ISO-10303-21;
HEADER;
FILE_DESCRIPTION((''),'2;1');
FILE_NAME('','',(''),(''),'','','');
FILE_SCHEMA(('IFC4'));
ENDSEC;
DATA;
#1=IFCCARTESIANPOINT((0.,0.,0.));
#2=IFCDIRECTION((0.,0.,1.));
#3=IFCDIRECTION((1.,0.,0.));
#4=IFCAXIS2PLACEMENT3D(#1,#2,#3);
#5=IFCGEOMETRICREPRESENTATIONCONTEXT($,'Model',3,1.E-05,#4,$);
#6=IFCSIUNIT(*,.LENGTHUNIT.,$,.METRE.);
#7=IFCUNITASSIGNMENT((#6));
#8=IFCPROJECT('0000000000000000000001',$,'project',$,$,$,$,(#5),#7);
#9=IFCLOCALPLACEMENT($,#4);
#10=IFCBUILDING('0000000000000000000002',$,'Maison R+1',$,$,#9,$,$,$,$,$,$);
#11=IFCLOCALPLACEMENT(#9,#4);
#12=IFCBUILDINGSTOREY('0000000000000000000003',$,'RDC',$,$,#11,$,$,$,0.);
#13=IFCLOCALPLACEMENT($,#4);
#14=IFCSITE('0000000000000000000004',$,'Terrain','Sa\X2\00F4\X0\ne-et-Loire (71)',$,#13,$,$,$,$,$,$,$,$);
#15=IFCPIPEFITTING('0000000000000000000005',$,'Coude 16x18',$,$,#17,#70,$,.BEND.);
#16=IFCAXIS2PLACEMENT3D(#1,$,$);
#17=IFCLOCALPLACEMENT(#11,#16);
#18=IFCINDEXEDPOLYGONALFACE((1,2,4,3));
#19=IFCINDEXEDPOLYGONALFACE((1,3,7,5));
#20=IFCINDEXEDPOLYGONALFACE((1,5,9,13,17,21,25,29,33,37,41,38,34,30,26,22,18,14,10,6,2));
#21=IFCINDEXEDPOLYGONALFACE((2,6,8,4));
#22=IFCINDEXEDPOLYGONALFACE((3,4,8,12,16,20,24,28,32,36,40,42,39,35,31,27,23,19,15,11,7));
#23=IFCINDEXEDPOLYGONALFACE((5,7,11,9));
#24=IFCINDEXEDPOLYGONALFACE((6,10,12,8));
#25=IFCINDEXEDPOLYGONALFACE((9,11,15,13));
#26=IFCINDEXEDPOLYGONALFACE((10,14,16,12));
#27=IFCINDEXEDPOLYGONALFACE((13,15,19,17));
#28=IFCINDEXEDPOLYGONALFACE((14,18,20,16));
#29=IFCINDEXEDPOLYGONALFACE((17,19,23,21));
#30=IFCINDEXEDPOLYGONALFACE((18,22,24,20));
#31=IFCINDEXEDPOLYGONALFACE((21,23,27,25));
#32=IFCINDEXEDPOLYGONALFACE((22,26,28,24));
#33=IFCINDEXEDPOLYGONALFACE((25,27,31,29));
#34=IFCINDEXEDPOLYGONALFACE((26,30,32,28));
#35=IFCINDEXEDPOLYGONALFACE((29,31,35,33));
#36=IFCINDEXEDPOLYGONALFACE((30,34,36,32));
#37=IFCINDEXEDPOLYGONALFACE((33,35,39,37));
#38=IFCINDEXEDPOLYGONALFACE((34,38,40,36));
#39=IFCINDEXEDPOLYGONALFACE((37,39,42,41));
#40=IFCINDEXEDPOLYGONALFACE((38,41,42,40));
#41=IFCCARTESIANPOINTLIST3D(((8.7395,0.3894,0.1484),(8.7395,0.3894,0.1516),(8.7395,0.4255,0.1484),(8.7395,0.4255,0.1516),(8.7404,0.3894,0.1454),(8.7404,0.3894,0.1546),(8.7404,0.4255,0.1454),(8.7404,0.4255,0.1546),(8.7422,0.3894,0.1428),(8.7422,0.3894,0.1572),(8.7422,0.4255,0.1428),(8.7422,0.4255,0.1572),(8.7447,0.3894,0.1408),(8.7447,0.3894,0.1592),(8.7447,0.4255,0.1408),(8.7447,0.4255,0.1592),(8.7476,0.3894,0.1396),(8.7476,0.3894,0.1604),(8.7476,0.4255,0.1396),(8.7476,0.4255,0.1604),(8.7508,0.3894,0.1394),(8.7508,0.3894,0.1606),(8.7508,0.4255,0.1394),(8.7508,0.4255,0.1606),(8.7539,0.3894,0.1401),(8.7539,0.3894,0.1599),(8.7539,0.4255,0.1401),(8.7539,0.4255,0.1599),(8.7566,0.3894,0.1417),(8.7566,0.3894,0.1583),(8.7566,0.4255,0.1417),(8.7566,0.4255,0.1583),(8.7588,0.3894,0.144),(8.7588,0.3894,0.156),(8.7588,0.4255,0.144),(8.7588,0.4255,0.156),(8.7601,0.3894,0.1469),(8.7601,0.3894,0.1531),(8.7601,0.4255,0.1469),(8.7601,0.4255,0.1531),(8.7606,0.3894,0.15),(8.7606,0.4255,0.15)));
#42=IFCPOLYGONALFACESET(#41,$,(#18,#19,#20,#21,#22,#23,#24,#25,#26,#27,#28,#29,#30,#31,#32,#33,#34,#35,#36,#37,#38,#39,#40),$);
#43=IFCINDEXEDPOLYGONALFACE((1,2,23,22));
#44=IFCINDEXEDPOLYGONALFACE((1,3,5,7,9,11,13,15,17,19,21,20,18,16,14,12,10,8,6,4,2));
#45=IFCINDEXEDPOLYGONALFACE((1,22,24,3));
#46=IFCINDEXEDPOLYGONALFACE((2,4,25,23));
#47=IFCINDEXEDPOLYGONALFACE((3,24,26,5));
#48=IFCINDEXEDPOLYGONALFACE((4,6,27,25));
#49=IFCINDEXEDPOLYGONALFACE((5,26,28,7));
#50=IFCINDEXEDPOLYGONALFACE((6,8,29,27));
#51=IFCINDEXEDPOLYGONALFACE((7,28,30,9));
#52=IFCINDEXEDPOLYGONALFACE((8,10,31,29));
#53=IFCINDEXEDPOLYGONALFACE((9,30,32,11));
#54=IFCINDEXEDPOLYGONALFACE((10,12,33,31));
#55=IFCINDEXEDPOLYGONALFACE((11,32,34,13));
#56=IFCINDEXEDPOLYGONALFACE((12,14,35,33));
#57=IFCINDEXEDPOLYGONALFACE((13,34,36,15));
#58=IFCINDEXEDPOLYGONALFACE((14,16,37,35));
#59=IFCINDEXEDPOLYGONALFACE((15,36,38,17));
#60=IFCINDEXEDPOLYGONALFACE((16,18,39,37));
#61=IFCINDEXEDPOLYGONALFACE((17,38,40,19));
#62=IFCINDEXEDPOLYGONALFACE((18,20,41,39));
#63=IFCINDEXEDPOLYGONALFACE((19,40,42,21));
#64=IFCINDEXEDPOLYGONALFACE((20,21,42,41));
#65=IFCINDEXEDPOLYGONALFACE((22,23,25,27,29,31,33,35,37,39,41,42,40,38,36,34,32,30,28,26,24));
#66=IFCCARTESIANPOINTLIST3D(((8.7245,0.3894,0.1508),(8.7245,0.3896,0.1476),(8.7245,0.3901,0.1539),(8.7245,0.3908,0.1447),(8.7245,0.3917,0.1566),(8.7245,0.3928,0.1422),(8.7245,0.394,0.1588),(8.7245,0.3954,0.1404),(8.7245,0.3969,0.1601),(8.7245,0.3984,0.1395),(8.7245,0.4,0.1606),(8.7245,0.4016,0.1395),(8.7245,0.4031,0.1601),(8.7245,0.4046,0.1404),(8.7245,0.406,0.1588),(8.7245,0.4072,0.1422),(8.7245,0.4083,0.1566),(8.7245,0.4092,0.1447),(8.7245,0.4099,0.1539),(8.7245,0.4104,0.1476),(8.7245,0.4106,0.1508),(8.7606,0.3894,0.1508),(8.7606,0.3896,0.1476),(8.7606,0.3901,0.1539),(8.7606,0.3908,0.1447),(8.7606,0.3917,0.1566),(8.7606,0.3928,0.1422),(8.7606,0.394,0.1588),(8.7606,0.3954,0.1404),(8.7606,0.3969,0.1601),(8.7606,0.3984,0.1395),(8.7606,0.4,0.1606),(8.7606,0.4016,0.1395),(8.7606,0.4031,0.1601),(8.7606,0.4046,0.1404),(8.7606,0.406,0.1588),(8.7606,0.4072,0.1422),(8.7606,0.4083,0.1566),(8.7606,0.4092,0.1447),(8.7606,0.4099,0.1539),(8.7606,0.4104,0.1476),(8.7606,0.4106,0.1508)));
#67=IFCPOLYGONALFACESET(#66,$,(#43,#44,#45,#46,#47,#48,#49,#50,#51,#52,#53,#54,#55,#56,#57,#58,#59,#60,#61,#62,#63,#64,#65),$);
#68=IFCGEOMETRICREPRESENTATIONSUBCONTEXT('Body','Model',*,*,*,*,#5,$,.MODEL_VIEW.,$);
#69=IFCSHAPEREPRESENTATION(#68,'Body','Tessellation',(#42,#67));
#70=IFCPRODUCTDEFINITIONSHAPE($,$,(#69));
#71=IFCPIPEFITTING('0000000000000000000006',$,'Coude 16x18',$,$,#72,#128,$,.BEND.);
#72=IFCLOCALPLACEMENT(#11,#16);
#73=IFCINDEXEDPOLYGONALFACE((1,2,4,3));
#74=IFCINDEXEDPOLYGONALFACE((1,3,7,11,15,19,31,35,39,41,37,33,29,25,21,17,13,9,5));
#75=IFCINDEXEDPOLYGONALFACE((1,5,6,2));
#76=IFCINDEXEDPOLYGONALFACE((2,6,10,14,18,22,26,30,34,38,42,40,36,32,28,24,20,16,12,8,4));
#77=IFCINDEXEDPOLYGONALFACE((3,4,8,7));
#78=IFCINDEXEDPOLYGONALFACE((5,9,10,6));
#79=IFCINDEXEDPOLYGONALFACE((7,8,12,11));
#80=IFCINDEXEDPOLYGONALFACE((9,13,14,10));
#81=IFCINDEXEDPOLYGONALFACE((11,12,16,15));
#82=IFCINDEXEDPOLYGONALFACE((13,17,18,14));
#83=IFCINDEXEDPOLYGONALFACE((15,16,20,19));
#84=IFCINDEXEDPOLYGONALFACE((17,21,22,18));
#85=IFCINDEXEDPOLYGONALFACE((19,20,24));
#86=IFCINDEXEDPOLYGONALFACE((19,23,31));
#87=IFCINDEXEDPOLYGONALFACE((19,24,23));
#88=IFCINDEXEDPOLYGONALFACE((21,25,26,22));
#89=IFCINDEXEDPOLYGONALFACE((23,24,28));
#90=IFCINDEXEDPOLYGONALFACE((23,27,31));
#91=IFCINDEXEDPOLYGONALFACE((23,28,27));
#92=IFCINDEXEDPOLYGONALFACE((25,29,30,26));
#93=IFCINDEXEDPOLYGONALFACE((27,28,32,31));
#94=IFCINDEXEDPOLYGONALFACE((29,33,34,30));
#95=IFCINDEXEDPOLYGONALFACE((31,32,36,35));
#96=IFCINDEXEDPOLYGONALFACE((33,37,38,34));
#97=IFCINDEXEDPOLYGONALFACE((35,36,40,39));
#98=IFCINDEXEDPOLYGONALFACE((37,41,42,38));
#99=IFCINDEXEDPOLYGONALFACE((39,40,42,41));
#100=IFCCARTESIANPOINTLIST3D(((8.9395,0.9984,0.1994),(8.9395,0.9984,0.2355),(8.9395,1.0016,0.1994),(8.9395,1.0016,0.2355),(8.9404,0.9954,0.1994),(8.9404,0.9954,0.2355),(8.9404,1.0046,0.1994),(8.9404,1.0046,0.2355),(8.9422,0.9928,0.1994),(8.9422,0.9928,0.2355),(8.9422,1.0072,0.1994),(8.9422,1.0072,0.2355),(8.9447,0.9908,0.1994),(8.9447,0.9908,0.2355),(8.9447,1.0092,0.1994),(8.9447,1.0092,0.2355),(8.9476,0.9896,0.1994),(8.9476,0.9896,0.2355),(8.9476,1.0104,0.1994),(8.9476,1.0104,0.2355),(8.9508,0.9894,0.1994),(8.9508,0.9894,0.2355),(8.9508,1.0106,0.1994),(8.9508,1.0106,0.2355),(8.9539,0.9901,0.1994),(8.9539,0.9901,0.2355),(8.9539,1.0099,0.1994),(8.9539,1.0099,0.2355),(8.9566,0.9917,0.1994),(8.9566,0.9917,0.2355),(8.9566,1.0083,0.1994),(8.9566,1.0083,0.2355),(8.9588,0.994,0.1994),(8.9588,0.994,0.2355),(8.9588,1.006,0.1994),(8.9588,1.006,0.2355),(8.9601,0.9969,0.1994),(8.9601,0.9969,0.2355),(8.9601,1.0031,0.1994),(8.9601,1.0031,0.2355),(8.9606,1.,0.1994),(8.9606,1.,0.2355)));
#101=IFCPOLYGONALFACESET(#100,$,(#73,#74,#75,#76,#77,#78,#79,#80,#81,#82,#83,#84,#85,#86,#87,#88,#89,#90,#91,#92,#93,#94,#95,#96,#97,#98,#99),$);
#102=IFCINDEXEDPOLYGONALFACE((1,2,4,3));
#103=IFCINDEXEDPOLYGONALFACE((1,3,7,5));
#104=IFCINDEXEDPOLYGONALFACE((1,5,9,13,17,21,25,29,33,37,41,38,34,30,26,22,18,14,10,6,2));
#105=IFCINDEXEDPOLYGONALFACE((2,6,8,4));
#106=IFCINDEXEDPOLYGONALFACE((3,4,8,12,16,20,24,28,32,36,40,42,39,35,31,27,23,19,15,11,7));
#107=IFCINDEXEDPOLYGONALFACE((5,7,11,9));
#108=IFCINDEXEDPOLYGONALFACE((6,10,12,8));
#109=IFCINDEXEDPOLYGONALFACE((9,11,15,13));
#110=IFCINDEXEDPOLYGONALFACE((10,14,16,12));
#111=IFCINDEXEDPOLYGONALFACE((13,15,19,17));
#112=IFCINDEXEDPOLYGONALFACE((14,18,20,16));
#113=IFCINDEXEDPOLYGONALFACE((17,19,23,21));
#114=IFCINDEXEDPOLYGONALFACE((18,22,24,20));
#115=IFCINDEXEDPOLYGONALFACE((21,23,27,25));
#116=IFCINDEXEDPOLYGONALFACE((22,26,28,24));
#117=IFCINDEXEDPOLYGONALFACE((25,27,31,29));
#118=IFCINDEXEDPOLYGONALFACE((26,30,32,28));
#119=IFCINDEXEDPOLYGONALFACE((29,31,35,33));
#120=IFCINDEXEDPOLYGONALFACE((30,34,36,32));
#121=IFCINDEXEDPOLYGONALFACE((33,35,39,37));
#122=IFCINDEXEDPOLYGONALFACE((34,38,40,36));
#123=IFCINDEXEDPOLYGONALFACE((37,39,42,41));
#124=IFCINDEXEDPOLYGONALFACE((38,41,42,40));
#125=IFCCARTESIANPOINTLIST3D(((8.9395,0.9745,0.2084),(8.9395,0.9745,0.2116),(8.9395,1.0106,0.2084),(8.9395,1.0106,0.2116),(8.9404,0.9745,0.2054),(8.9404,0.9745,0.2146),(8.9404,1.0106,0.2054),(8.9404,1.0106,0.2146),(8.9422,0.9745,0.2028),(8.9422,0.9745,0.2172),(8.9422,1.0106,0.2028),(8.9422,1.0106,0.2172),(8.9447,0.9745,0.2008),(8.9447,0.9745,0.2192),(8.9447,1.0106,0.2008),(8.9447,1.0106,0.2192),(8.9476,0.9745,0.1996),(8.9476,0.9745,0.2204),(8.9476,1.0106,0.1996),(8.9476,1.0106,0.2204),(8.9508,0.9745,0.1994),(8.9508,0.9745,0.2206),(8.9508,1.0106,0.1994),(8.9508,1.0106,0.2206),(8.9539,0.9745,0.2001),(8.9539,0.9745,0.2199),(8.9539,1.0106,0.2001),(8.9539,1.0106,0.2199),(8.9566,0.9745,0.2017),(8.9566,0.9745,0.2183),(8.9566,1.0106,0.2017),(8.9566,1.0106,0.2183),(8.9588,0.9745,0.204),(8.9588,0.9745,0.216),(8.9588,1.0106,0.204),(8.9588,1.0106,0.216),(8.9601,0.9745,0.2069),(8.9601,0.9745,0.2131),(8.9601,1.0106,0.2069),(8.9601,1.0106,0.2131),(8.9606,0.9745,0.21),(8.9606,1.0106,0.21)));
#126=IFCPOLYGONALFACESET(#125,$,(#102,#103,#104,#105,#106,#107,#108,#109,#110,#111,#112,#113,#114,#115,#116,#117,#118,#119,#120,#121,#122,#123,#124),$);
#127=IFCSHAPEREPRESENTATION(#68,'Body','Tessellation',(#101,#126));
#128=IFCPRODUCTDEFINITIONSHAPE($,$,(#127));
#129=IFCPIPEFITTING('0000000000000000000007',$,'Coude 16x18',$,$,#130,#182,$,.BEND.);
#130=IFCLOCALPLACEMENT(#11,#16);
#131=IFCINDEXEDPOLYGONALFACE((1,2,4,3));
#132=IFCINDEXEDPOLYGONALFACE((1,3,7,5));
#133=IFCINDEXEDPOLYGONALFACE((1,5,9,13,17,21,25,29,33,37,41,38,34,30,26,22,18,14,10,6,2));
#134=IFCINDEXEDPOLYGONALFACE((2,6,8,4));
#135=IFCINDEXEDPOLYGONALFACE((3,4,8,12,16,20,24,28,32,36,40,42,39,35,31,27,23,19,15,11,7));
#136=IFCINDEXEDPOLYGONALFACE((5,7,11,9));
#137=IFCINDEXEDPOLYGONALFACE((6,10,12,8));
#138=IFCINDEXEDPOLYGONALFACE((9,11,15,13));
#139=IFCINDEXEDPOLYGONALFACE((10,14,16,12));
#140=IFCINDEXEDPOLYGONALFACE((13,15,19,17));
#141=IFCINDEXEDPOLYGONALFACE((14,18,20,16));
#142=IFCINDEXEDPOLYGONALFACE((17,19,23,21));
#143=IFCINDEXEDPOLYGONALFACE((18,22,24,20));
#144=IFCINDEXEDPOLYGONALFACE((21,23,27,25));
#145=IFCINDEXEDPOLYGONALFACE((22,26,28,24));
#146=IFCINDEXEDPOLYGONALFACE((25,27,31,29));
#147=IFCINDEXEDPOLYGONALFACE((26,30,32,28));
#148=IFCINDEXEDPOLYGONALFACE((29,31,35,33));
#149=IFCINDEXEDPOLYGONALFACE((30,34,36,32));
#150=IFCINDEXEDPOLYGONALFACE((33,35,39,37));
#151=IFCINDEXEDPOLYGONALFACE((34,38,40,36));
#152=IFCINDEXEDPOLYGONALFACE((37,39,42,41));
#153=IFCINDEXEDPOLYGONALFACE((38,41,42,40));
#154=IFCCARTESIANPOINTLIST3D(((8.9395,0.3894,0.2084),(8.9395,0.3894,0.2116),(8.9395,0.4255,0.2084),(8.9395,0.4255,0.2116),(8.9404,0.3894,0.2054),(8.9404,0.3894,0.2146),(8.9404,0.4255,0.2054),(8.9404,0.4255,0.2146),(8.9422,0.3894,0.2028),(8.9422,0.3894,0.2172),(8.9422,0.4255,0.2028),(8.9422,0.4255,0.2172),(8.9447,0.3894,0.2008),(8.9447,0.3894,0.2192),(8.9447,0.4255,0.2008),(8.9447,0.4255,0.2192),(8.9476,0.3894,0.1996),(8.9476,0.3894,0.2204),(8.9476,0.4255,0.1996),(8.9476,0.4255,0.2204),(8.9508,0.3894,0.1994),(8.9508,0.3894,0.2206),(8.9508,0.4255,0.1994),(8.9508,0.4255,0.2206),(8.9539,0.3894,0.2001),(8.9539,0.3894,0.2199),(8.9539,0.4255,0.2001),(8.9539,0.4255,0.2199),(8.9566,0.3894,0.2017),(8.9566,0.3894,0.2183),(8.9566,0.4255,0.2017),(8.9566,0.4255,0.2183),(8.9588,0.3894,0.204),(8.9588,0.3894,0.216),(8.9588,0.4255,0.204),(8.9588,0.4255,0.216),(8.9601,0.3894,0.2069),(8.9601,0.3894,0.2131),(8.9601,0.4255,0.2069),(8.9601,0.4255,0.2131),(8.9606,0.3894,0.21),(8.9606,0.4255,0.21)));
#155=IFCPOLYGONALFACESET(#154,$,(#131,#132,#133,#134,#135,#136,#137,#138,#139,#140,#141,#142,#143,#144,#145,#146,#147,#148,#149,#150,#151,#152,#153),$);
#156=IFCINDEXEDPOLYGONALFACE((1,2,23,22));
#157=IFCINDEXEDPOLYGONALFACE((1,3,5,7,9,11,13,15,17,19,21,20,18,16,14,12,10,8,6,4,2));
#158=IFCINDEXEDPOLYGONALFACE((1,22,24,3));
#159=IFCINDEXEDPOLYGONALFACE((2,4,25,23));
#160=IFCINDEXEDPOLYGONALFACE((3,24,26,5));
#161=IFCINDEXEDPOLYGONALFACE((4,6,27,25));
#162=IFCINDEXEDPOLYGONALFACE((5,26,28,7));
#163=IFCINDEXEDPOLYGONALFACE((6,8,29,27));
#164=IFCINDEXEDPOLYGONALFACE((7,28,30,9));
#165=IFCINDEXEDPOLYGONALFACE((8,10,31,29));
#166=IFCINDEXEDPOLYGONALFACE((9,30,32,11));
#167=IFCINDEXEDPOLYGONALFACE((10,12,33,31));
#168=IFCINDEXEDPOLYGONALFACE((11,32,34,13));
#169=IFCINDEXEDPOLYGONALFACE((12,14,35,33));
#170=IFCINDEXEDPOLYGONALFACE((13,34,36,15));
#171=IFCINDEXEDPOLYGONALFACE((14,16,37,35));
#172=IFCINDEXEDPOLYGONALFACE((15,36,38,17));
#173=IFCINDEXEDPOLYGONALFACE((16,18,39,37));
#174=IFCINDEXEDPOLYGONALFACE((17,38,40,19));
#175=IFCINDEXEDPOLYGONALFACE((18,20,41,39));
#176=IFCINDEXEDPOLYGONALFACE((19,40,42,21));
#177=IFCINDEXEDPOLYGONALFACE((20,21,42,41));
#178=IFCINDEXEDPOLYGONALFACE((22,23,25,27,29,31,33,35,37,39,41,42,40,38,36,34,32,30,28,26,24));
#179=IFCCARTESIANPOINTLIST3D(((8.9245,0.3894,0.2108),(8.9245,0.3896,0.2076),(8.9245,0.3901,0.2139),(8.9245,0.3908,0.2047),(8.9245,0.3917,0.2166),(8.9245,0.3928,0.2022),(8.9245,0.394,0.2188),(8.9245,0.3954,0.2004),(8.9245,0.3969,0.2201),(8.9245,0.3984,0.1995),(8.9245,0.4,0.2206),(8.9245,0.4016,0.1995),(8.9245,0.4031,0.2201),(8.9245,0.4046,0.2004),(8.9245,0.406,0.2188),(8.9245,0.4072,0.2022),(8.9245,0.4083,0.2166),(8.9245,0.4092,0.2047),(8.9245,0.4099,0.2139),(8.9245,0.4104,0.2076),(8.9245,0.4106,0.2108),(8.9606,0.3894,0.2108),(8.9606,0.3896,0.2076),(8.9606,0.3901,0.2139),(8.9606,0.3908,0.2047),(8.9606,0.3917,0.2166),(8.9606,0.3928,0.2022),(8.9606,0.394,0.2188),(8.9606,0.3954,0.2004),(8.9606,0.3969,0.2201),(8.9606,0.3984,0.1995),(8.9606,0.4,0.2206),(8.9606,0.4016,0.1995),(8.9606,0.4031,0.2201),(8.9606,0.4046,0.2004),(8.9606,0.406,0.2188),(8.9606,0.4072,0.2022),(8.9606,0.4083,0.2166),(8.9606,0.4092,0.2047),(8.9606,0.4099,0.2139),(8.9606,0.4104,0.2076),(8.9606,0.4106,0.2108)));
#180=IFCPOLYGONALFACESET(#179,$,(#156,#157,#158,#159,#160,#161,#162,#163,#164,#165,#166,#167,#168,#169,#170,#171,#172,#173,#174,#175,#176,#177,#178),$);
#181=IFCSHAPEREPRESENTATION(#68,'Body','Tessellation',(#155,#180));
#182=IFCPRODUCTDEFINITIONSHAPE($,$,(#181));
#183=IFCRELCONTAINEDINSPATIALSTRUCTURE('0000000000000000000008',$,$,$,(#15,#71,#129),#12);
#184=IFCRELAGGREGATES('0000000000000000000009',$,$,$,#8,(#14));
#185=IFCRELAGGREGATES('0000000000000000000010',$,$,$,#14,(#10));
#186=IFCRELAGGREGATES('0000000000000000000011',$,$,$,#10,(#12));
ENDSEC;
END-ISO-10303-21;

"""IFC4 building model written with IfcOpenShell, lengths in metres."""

from ifc_helpers import new_model, si_unit, frame, origin_with_axes, place, context, subcontext, project, spatial, circle, extrude, element, save


model = new_model("IFC4")

# Units and contexts
model_context = context("Model", 3, precision=1e-05, world=origin_with_axes())
body_context = subcontext(model_context, "Body", "Model", "MODEL_VIEW")
ifc_project = project(units=[si_unit("LENGTHUNIT", "METRE")], contexts=[model_context])

# Site, building, storey
site_placement = place(None, origin_with_axes())
site = spatial("IfcSite", under=ifc_project, at=site_placement, Name="Terrain", Description="Saône-et-Loire (71)")
building_placement = place(None, origin_with_axes())
building = spatial("IfcBuilding", under=site, at=building_placement, Name="Maison R+1")
storey_placement = place(building_placement, origin_with_axes())
storey = spatial("IfcBuildingStorey", under=building, at=storey_placement, Name="RDC", Elevation=0.0)

# Pipe fittings
pipe_fitting_1_placement = place(storey_placement, frame((8.75, 0.4, 0.15), z_axis=(0.0, 0.0, 1.0), x_axis=(1.0, 0.0, 0.0)))
element("IfcPipeFitting", 1, at=pipe_fitting_1_placement, inside=storey, Name="Coude 16x18", PredefinedType="BEND", context=body_context, shape_type="SweptSolid", body=[
    extrude(circle(Radius=0.0106), frame((0.0, -0.0106, 0.0), z_axis=(0.0, 1.0, 0.0), x_axis=(1.0, 0.0, 0.0)), (0.0, 0.0, 1.0), 0.0361),
    extrude(circle(Radius=0.0106), frame((0.0106, 0.0, 0.0), z_axis=(-1.0, 0.0, 0.0), x_axis=(0.0, 0.0, 1.0)), (0.0, 0.0, 1.0), 0.0361),
])
pipe_fitting_2_placement = place(storey_placement, frame((8.95, 1.0, 0.21), z_axis=(0.0, 0.0, 1.0), x_axis=(1.0, 0.0, 0.0)))
element("IfcPipeFitting", 2, at=pipe_fitting_2_placement, inside=storey, Name="Coude 16x18", PredefinedType="BEND", context=body_context, shape_type="SweptSolid", body=[
    extrude(circle(Radius=0.0106), frame((0.0, 0.0, -0.0106), z_axis=(0.0, 0.0, 1.0), x_axis=(1.0, 0.0, 0.0)), (0.0, 0.0, 1.0), 0.0361),
    extrude(circle(Radius=0.0106), frame((0.0, 0.0106, 0.0), z_axis=(0.0, -1.0, 0.0), x_axis=(1.0, 0.0, 0.0)), (0.0, 0.0, 1.0), 0.0361),
])
pipe_fitting_3_placement = place(storey_placement, frame((8.95, 0.4, 0.21), z_axis=(0.0, 0.0, 1.0), x_axis=(1.0, 0.0, 0.0)))
element("IfcPipeFitting", 3, at=pipe_fitting_3_placement, inside=storey, Name="Coude 16x18", PredefinedType="BEND", context=body_context, shape_type="SweptSolid", body=[
    extrude(circle(Radius=0.0106), frame((0.0, -0.0106, 0.0), z_axis=(0.0, 1.0, 0.0), x_axis=(1.0, 0.0, 0.0)), (0.0, 0.0, 1.0), 0.0361),
    extrude(circle(Radius=0.0106), frame((0.0106, 0.0, 0.0), z_axis=(-1.0, 0.0, 0.0), x_axis=(0.0, 0.0, 1.0)), (0.0, 0.0, 1.0), 0.0361),
])

save(model, "model.ifc")
